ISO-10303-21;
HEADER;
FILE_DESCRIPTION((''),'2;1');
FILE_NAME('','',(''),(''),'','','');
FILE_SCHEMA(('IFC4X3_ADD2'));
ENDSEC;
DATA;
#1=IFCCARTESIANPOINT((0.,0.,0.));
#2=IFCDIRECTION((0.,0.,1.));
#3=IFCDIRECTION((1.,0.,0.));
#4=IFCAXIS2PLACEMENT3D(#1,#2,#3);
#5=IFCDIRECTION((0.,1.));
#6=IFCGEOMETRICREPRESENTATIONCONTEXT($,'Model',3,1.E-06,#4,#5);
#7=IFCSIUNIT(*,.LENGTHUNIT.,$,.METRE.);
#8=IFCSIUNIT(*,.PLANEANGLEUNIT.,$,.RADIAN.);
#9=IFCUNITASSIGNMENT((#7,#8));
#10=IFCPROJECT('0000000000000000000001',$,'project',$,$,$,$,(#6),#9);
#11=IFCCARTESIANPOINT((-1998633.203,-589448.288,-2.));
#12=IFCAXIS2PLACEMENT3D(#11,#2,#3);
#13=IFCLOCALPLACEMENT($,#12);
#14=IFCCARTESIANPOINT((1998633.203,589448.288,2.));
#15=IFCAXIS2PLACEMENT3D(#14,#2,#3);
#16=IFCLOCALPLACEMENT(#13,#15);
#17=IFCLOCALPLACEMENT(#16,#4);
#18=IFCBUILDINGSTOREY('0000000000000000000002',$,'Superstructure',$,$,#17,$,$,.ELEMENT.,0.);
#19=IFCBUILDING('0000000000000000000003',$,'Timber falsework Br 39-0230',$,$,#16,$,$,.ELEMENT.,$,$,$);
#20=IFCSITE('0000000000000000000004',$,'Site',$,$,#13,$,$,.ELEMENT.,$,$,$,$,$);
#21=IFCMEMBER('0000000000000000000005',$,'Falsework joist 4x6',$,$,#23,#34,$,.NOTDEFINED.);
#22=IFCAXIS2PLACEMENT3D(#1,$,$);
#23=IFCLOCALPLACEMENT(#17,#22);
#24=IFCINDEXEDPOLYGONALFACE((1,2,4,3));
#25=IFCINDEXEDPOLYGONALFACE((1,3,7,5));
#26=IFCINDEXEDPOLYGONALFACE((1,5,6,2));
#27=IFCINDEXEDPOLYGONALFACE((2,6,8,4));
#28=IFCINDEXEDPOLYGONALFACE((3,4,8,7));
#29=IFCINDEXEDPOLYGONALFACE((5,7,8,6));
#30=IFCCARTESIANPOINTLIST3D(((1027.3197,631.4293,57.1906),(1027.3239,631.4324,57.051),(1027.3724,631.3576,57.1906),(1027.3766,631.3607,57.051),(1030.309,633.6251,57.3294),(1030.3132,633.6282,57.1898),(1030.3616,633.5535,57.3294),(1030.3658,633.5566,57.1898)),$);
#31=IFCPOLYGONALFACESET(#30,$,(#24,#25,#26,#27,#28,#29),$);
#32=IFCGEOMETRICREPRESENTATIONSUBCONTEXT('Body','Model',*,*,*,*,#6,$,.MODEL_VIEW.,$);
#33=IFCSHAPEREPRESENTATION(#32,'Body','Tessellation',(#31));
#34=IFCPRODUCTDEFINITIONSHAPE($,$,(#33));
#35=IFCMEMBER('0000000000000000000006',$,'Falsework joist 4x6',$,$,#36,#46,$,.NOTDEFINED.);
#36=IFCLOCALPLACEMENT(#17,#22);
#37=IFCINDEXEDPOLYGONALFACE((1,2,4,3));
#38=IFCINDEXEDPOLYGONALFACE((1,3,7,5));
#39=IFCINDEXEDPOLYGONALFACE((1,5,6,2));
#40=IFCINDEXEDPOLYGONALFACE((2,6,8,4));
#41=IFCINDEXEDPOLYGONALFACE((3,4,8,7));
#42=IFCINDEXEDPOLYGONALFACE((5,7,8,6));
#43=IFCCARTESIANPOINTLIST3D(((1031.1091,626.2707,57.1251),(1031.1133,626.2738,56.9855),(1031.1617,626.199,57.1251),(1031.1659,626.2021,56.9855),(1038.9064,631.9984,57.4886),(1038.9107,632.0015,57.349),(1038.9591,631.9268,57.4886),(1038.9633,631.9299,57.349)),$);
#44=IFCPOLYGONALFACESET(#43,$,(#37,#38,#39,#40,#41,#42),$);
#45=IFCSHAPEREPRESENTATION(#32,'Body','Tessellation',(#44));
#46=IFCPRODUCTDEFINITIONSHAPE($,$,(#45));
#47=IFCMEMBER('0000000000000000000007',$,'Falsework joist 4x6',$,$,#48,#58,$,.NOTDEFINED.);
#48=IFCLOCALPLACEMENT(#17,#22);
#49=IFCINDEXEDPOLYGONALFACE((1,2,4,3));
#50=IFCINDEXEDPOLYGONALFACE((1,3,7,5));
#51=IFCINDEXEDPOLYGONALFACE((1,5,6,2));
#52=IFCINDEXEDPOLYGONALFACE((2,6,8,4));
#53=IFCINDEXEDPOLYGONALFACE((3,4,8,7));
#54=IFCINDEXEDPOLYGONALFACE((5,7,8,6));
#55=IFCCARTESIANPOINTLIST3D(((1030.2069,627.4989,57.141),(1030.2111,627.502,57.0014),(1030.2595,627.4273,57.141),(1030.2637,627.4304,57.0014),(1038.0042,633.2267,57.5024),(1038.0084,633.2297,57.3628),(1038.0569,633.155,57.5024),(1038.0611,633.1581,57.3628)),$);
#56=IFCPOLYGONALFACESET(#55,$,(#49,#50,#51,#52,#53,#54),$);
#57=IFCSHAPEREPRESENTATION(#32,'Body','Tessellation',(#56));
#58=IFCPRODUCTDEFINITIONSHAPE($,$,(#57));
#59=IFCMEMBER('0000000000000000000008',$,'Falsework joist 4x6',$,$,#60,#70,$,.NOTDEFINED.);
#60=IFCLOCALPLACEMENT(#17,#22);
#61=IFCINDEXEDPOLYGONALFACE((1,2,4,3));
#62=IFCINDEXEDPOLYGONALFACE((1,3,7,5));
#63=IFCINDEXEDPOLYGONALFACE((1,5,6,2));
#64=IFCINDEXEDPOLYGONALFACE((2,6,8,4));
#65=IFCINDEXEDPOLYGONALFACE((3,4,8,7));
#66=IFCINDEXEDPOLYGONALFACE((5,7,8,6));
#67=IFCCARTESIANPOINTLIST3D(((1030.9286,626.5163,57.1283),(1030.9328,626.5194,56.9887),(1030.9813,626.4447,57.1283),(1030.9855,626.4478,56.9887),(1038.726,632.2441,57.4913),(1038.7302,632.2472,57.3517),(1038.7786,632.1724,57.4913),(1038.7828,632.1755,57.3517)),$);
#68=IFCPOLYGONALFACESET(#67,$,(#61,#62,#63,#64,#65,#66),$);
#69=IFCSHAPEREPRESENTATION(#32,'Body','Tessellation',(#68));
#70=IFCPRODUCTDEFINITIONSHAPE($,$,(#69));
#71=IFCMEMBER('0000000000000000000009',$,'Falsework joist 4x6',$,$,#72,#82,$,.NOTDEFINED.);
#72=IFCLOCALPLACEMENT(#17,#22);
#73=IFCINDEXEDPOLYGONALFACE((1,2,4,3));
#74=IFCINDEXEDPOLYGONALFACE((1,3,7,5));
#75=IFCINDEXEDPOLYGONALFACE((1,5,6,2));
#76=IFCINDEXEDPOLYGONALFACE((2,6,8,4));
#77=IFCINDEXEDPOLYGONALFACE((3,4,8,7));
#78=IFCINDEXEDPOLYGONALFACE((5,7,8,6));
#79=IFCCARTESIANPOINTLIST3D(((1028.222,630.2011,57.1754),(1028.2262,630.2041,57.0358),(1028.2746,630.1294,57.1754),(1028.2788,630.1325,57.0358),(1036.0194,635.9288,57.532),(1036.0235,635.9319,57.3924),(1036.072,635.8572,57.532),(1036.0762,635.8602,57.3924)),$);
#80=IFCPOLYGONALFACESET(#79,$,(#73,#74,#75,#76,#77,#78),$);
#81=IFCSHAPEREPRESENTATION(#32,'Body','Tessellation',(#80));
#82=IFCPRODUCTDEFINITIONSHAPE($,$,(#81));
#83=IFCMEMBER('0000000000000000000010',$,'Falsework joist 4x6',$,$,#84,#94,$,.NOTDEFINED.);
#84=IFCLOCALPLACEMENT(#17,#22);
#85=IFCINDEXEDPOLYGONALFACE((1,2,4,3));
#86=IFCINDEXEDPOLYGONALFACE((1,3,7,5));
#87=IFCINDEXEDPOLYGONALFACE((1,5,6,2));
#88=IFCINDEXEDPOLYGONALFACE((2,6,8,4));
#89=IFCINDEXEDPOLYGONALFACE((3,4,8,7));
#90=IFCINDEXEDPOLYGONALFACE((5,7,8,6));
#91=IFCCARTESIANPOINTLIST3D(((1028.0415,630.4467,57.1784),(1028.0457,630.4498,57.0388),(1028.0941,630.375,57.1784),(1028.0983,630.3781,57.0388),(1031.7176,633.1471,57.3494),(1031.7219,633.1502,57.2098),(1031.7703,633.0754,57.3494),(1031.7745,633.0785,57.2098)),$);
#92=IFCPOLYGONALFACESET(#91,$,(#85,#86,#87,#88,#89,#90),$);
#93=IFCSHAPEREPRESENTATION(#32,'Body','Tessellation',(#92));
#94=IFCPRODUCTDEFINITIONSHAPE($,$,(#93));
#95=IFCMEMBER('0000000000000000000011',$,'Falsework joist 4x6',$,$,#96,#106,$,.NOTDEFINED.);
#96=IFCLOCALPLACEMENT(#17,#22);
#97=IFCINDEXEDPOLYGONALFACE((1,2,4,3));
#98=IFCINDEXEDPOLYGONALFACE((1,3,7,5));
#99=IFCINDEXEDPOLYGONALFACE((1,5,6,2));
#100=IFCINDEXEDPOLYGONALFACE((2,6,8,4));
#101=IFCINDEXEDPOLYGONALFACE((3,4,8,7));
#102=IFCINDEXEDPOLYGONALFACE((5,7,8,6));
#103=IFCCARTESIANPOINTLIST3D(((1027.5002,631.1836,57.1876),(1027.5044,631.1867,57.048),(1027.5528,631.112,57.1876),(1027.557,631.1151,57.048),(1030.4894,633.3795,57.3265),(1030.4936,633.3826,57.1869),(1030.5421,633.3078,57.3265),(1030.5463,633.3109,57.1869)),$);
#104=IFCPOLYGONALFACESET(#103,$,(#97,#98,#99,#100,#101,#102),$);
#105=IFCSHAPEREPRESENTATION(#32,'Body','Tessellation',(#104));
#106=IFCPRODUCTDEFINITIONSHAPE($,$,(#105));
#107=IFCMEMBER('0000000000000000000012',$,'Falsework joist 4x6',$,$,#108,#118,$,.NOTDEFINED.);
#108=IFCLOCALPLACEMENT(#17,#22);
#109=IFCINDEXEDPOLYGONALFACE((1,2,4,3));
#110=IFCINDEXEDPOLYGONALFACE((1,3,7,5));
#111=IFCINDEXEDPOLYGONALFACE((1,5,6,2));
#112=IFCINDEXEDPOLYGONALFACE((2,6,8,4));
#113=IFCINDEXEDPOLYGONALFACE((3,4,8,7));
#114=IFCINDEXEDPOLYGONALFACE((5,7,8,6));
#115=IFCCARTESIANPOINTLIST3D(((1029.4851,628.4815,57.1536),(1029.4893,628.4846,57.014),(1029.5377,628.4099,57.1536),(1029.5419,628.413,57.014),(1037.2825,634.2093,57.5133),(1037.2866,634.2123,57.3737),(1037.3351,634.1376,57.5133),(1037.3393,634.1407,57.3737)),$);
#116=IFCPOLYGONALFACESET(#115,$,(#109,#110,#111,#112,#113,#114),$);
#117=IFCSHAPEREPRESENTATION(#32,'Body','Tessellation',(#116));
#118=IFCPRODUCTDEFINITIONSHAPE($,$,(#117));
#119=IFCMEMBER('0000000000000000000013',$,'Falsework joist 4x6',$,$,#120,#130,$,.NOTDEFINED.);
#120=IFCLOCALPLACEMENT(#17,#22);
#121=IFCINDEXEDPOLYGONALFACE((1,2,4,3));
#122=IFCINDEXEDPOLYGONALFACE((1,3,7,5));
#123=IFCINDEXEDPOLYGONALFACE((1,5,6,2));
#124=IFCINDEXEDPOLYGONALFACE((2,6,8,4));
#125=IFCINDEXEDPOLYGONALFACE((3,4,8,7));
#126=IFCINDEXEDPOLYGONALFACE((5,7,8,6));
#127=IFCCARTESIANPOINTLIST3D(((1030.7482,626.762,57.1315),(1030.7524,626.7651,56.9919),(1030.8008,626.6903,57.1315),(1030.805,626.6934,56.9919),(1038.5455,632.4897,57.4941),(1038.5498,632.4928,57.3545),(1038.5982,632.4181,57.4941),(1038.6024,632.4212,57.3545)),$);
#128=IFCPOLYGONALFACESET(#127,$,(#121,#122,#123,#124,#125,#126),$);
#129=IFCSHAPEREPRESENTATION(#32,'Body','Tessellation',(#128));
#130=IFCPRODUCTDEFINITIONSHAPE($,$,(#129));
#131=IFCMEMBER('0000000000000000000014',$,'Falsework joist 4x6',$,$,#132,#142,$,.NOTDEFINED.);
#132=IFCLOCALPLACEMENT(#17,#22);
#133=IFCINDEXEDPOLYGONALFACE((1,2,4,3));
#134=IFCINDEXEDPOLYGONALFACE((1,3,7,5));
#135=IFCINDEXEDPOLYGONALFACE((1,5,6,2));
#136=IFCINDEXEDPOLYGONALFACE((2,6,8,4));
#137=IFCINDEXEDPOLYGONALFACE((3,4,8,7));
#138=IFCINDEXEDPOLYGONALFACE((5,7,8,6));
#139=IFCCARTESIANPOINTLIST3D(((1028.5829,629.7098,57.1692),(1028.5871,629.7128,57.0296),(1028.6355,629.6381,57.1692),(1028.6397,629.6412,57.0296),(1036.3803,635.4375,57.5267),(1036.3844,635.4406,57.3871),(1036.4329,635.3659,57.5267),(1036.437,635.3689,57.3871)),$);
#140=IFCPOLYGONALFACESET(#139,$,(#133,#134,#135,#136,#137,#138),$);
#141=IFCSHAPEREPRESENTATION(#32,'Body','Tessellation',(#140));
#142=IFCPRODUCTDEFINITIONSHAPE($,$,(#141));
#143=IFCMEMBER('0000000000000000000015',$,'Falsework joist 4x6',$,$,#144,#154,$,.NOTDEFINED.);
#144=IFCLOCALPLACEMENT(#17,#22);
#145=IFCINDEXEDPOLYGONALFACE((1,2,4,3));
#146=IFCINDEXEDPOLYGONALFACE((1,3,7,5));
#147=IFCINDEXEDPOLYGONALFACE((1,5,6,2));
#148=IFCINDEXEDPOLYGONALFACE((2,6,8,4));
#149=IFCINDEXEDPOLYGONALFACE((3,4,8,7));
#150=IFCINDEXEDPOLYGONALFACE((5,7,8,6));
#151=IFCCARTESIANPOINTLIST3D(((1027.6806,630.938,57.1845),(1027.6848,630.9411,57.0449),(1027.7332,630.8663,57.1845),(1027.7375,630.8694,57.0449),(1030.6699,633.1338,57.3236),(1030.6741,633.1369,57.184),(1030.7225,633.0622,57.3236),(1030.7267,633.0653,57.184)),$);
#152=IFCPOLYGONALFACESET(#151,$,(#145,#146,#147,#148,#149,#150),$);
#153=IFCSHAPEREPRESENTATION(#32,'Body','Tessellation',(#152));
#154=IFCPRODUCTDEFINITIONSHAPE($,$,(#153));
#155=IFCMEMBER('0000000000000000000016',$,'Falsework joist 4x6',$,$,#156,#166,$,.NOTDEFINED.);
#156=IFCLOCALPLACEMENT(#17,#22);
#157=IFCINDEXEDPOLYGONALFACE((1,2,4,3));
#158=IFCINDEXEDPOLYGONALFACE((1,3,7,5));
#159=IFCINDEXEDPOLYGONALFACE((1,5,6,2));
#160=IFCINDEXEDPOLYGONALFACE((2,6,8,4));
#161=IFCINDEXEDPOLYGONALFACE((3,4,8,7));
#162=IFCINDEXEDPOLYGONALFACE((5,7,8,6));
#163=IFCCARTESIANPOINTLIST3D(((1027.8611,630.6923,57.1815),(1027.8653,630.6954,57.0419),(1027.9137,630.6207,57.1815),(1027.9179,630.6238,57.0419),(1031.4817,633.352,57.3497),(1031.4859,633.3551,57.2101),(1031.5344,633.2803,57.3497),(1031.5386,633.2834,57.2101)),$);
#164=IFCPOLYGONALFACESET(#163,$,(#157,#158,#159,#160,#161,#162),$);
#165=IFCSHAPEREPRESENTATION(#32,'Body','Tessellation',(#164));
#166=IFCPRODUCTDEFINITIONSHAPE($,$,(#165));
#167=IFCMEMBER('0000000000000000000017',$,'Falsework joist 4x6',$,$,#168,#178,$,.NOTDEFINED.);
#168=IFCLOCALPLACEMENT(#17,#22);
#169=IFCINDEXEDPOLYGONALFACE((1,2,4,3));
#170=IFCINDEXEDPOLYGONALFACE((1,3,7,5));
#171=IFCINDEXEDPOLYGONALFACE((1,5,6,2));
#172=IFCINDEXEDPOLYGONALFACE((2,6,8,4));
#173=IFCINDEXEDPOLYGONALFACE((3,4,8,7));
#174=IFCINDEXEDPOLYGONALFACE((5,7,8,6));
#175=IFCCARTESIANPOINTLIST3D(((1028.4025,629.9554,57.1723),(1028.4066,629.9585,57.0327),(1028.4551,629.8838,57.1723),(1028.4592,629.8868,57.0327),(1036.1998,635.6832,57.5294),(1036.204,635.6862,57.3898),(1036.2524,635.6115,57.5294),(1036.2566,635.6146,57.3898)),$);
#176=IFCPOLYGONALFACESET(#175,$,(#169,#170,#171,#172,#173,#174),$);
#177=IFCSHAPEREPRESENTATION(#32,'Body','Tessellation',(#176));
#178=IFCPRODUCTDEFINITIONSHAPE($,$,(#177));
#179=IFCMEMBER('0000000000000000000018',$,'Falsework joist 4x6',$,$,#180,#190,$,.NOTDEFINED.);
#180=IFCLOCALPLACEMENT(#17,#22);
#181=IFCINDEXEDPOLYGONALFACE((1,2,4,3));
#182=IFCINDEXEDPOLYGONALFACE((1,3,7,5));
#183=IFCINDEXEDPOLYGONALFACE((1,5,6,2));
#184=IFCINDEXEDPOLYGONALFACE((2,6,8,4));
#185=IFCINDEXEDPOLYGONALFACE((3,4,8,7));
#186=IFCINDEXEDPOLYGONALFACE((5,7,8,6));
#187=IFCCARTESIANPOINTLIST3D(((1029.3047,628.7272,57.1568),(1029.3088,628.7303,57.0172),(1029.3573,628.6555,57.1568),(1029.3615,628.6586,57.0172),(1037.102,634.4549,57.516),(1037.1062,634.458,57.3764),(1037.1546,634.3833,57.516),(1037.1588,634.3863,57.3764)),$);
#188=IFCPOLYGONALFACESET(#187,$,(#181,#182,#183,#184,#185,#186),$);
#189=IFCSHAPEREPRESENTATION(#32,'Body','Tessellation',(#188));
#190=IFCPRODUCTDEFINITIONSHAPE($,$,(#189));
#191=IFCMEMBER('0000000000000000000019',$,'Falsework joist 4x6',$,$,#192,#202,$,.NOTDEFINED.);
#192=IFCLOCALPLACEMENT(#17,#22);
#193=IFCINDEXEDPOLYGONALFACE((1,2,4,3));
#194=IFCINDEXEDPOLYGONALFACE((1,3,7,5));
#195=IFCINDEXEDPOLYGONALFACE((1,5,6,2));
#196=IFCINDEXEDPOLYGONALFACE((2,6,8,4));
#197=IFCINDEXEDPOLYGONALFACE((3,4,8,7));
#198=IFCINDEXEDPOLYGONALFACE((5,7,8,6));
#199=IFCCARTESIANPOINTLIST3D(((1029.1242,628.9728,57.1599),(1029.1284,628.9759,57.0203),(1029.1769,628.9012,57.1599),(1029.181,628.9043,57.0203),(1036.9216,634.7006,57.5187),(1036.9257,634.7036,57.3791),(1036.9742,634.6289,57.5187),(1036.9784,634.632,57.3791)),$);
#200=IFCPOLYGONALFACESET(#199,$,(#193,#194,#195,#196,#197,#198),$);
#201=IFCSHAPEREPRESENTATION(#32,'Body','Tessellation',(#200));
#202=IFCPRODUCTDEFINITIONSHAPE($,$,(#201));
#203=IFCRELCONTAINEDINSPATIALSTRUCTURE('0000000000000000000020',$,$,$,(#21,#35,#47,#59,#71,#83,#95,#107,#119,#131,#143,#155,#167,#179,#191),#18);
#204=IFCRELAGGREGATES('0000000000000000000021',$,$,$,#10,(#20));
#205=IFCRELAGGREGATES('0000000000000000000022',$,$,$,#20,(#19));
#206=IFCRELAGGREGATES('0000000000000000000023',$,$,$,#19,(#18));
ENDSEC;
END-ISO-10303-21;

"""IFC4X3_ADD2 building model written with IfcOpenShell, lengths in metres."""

from ifc_helpers import new_model, si_unit, direction, frame, frame_2d, origin, origin_with_axes, place, context, subcontext, project, spatial, rectangle, extrude, element, save


model = new_model("IFC4X3_ADD2")

# Units and contexts
model_context = context("Model", 3, precision=1e-06, world=origin_with_axes(), true_north=direction((0.0, 1.0)))
body_context = subcontext(model_context, "Body", "Model", "MODEL_VIEW")
ifc_project = project(units=[si_unit("LENGTHUNIT", "METRE"), si_unit("PLANEANGLEUNIT", "RADIAN")], contexts=[model_context])

# Site, building, storey
site_placement = place(None, frame((-1998633.203, -589448.288, -2.0), z_axis=(0.0, 0.0, 1.0), x_axis=(1.0, 0.0, 0.0)))
site = spatial("IfcSite", under=ifc_project, at=site_placement, Name="Site", CompositionType="ELEMENT")
building_placement = place(site_placement, frame((1998633.203, 589448.288, 2.0), z_axis=(0.0, 0.0, 1.0), x_axis=(1.0, 0.0, 0.0)))
building = spatial("IfcBuilding", under=site, at=building_placement, Name="Timber falsework Br 39-0230", CompositionType="ELEMENT")
storey_placement = place(building_placement, origin_with_axes())
storey = spatial("IfcBuildingStorey", under=building, at=storey_placement, Name="Superstructure", CompositionType="ELEMENT", Elevation=0.0)

# Members
member_1_placement = place(storey_placement, frame((1027.3503, 631.3965, 57.051), z_axis=(0.805365, 0.591599, 0.03738), x_axis=(-0.592013, 0.805928, 0.0)))
element("IfcMember", 1, at=member_1_placement, inside=storey, Name="Falsework joist 4x6", PredefinedType="NOTDEFINED", context=body_context, shape_type="SweptSolid", body=[
    extrude(rectangle(XDim=0.0889, YDim=0.1397, at=frame_2d((0.0, 0.0698))), origin(), (0.0, 0.0, 1.0), 3.7117),
])
member_2_placement = place(storey_placement, frame((1031.1396, 626.238, 56.9855), z_axis=(0.80536, 0.591596, 0.037539), x_axis=(-0.592013, 0.805928, 0.0)))
element("IfcMember", 2, at=member_2_placement, inside=storey, Name="Falsework joist 4x6", PredefinedType="NOTDEFINED", context=body_context, shape_type="SweptSolid", body=[
    extrude(rectangle(XDim=0.0889, YDim=0.1397, at=frame_2d((0.0, 0.0698))), origin(), (0.0, 0.0, 1.0), 9.6818),
])
member_3_placement = place(storey_placement, frame((1030.2374, 627.4662, 57.0014), z_axis=(0.805367, 0.591601, 0.037321), x_axis=(-0.592013, 0.805928, 0.0)))
element("IfcMember", 3, at=member_3_placement, inside=storey, Name="Falsework joist 4x6", PredefinedType="NOTDEFINED", context=body_context, shape_type="SweptSolid", body=[
    extrude(rectangle(XDim=0.0889, YDim=0.1397, at=frame_2d((0.0, 0.0698))), origin(), (0.0, 0.0, 1.0), 9.6817),
])
member_4_placement = place(storey_placement, frame((1030.9592, 626.4836, 56.9887), z_axis=(0.805362, 0.591597, 0.037495), x_axis=(-0.592013, 0.805928, 0.0)))
element("IfcMember", 4, at=member_4_placement, inside=storey, Name="Falsework joist 4x6", PredefinedType="NOTDEFINED", context=body_context, shape_type="SweptSolid", body=[
    extrude(rectangle(XDim=0.0889, YDim=0.1397, at=frame_2d((0.0, 0.0698))), origin(), (0.0, 0.0, 1.0), 9.6818),
])
member_5_placement = place(storey_placement, frame((1028.2525, 630.1683, 57.0358), z_axis=(0.805381, 0.591611, 0.036839), x_axis=(-0.592013, 0.805928, 0.0)))
element("IfcMember", 5, at=member_5_placement, inside=storey, Name="Falsework joist 4x6", PredefinedType="NOTDEFINED", context=body_context, shape_type="SweptSolid", body=[
    extrude(rectangle(XDim=0.0889, YDim=0.1397, at=frame_2d((0.0, 0.0698))), origin(), (0.0, 0.0, 1.0), 9.6816),
])
member_6_placement = place(storey_placement, frame((1028.072, 630.414, 57.0388), z_axis=(0.805363, 0.591598, 0.03745), x_axis=(-0.592013, 0.805928, 0.0)))
element("IfcMember", 6, at=member_6_placement, inside=storey, Name="Falsework joist 4x6", PredefinedType="NOTDEFINED", context=body_context, shape_type="SweptSolid", body=[
    extrude(rectangle(XDim=0.0889, YDim=0.1397, at=frame_2d((0.0, 0.0698))), origin(), (0.0, 0.0, 1.0), 4.5646),
])
member_7_placement = place(storey_placement, frame((1027.5307, 631.1509, 57.048), z_axis=(0.805364, 0.591598, 0.037427), x_axis=(-0.592013, 0.805928, 0.0)))
element("IfcMember", 7, at=member_7_placement, inside=storey, Name="Falsework joist 4x6", PredefinedType="NOTDEFINED", context=body_context, shape_type="SweptSolid", body=[
    extrude(rectangle(XDim=0.0889, YDim=0.1397, at=frame_2d((0.0, 0.0698))), origin(), (0.0, 0.0, 1.0), 3.7117),
])
member_8_placement = place(storey_placement, frame((1029.5156, 628.4488, 57.014), z_axis=(0.805372, 0.591605, 0.037146), x_axis=(-0.592013, 0.805928, 0.0)))
element("IfcMember", 8, at=member_8_placement, inside=storey, Name="Falsework joist 4x6", PredefinedType="NOTDEFINED", context=body_context, shape_type="SweptSolid", body=[
    extrude(rectangle(XDim=0.0889, YDim=0.1397, at=frame_2d((0.0, 0.0698))), origin(), (0.0, 0.0, 1.0), 9.6817),
])
member_9_placement = place(storey_placement, frame((1030.7787, 626.7293, 56.9919), z_axis=(0.805363, 0.591598, 0.037452), x_axis=(-0.592013, 0.805928, 0.0)))
element("IfcMember", 9, at=member_9_placement, inside=storey, Name="Falsework joist 4x6", PredefinedType="NOTDEFINED", context=body_context, shape_type="SweptSolid", body=[
    extrude(rectangle(XDim=0.0889, YDim=0.1397, at=frame_2d((0.0, 0.0698))), origin(), (0.0, 0.0, 1.0), 9.6818),
])
member_10_placement = place(storey_placement, frame((1028.6134, 629.677, 57.0296), z_axis=(0.805379, 0.591609, 0.036927), x_axis=(-0.592013, 0.805928, 0.0)))
element("IfcMember", 10, at=member_10_placement, inside=storey, Name="Falsework joist 4x6", PredefinedType="NOTDEFINED", context=body_context, shape_type="SweptSolid", body=[
    extrude(rectangle(XDim=0.0889, YDim=0.1397, at=frame_2d((0.0, 0.0698))), origin(), (0.0, 0.0, 1.0), 9.6816),
])
member_11_placement = place(storey_placement, frame((1027.7111, 630.9053, 57.0449), z_axis=(0.805362, 0.591597, 0.037474), x_axis=(-0.592013, 0.805928, 0.0)))
element("IfcMember", 11, at=member_11_placement, inside=storey, Name="Falsework joist 4x6", PredefinedType="NOTDEFINED", context=body_context, shape_type="SweptSolid", body=[
    extrude(rectangle(XDim=0.0889, YDim=0.1397, at=frame_2d((0.0, 0.0698))), origin(), (0.0, 0.0, 1.0), 3.7117),
])
member_12_placement = place(storey_placement, frame((1027.8916, 630.6596, 57.0419), z_axis=(0.805364, 0.591599, 0.037412), x_axis=(-0.592013, 0.805928, 0.0)))
element("IfcMember", 12, at=member_12_placement, inside=storey, Name="Falsework joist 4x6", PredefinedType="NOTDEFINED", context=body_context, shape_type="SweptSolid", body=[
    extrude(rectangle(XDim=0.0889, YDim=0.1397, at=frame_2d((0.0, 0.0698))), origin(), (0.0, 0.0, 1.0), 4.4957),
])
member_13_placement = place(storey_placement, frame((1028.4329, 629.9227, 57.0327), z_axis=(0.80538, 0.59161, 0.036883), x_axis=(-0.592013, 0.805928, 0.0)))
element("IfcMember", 13, at=member_13_placement, inside=storey, Name="Falsework joist 4x6", PredefinedType="NOTDEFINED", context=body_context, shape_type="SweptSolid", body=[
    extrude(rectangle(XDim=0.0889, YDim=0.1397, at=frame_2d((0.0, 0.0698))), origin(), (0.0, 0.0, 1.0), 9.6816),
])
member_14_placement = place(storey_placement, frame((1029.3352, 628.6944, 57.0172), z_axis=(0.805373, 0.591606, 0.037102), x_axis=(-0.592013, 0.805928, 0.0)))
element("IfcMember", 14, at=member_14_placement, inside=storey, Name="Falsework joist 4x6", PredefinedType="NOTDEFINED", context=body_context, shape_type="SweptSolid", body=[
    extrude(rectangle(XDim=0.0889, YDim=0.1397, at=frame_2d((0.0, 0.0698))), origin(), (0.0, 0.0, 1.0), 9.6817),
])
member_15_placement = place(storey_placement, frame((1029.1547, 628.9401, 57.0203), z_axis=(0.805375, 0.591607, 0.037058), x_axis=(-0.592013, 0.805928, 0.0)))
element("IfcMember", 15, at=member_15_placement, inside=storey, Name="Falsework joist 4x6", PredefinedType="NOTDEFINED", context=body_context, shape_type="SweptSolid", body=[
    extrude(rectangle(XDim=0.0889, YDim=0.1397, at=frame_2d((0.0, 0.0698))), origin(), (0.0, 0.0, 1.0), 9.6817),
])

save(model, "model.ifc")
